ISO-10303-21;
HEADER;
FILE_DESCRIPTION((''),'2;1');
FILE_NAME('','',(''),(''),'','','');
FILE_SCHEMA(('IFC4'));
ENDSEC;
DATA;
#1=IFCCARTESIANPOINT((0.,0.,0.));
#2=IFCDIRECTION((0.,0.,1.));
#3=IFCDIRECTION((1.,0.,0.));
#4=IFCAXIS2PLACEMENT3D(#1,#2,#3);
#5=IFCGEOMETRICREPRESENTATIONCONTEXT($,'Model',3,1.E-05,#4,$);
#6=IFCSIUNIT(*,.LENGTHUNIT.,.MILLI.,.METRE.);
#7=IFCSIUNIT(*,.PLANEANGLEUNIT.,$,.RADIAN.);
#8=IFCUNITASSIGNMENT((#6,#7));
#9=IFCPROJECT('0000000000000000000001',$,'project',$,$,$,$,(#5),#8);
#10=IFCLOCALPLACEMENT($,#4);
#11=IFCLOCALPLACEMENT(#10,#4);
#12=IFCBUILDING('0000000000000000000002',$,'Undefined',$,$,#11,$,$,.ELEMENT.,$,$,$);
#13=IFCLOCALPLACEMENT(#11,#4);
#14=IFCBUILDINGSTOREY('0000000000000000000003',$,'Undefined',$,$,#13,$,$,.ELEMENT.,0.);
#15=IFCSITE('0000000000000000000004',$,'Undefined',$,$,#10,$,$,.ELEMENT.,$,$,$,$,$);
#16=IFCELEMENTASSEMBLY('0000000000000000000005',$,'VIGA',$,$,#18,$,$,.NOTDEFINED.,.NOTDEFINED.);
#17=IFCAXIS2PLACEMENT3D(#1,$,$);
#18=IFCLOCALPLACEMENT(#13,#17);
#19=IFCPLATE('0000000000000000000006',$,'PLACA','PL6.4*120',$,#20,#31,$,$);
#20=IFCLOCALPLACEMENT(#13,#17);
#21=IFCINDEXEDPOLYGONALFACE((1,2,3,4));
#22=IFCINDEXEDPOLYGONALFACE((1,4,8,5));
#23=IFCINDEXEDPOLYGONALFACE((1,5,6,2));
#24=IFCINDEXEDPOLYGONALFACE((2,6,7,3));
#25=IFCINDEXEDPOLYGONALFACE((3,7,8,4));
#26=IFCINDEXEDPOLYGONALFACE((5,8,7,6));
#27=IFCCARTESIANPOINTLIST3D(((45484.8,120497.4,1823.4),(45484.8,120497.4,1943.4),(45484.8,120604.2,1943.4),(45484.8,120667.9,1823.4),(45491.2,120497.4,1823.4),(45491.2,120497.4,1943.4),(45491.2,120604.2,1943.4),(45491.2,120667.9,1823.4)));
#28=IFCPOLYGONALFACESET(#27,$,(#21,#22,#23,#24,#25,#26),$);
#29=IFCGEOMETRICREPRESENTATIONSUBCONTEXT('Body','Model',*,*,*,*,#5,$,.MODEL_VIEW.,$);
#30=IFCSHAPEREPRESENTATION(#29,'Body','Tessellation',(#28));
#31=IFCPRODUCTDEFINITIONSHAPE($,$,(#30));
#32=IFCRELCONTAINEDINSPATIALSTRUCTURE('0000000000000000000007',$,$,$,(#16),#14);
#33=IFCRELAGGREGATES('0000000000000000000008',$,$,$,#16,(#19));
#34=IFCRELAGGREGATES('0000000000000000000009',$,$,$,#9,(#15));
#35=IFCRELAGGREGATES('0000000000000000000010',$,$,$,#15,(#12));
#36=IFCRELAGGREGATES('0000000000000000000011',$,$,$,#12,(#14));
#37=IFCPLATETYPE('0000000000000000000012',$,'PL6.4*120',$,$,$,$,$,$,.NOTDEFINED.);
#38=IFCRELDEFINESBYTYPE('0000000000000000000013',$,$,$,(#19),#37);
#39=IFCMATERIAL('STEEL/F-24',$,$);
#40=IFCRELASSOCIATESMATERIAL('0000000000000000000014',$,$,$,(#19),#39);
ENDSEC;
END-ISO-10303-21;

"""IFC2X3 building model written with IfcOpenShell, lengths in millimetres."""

from ifc_helpers import new_model, si_unit, frame, origin_with_axes, place, context, subcontext, project, spatial, polyline, outline, extrude, material, type_object, element, aggregate, save


model = new_model("IFC2X3")

# Units and contexts
model_context = context("Model", 3, precision=1e-05, world=origin_with_axes())
body_context = subcontext(model_context, "Body", "Model", "MODEL_VIEW")
ifc_project = project(units=[si_unit("LENGTHUNIT", "METRE", prefix="MILLI"), si_unit("PLANEANGLEUNIT", "RADIAN")], contexts=[model_context])

# Site, building, storey
site_placement = place(None, origin_with_axes())
site = spatial("IfcSite", under=ifc_project, at=site_placement, Name="Undefined", CompositionType="ELEMENT")
building_placement = place(site_placement, origin_with_axes())
building = spatial("IfcBuilding", under=site, at=building_placement, Name="Undefined", CompositionType="ELEMENT")
storey_placement = place(building_placement, origin_with_axes())
storey = spatial("IfcBuildingStorey", under=building, at=storey_placement, Name="Undefined", CompositionType="ELEMENT", Elevation=0.0)

# Element assembly
ifc_material_1 = material(Name="STEEL/F-24")
assembly_1_placement = place(storey_placement, origin_with_axes())
assembly_1 = element("IfcElementAssembly", 1, at=assembly_1_placement, inside=storey, Name="VIGA", AssemblyPlace="NOTDEFINED", PredefinedType="NOTDEFINED")

# Plate
plate_type_1 = type_object("IfcPlateType", Name="PL6.4*120", PredefinedType="NOTDEFINED")
plate_1_placement = place(assembly_1_placement, frame((45488.0, 120604.2, 1943.4), z_axis=(1.0, 0.0, 0.0), x_axis=(0.0, -1.0, 0.0)))
plate_1 = element("IfcPlate", 2, at=plate_1_placement, type_object=plate_type_1, material=ifc_material_1, Name="PLACA", Description="PL6.4*120", context=body_context, shape_type="SweptSolid", body=[
    extrude(outline(polyline([(0.0, 0.0), (106.8, 0.0), (106.8, 120.0), (-63.7, 120.0), (0.0, 0.0)])), frame((0.0, 0.0, -3.2), z_axis=(0.0, 0.0, 1.0), x_axis=(1.0, 0.0, 0.0)), (0.0, 0.0, 1.0), 6.4),
])
aggregate(assembly_1, [plate_1])

save(model, "model.ifc")
